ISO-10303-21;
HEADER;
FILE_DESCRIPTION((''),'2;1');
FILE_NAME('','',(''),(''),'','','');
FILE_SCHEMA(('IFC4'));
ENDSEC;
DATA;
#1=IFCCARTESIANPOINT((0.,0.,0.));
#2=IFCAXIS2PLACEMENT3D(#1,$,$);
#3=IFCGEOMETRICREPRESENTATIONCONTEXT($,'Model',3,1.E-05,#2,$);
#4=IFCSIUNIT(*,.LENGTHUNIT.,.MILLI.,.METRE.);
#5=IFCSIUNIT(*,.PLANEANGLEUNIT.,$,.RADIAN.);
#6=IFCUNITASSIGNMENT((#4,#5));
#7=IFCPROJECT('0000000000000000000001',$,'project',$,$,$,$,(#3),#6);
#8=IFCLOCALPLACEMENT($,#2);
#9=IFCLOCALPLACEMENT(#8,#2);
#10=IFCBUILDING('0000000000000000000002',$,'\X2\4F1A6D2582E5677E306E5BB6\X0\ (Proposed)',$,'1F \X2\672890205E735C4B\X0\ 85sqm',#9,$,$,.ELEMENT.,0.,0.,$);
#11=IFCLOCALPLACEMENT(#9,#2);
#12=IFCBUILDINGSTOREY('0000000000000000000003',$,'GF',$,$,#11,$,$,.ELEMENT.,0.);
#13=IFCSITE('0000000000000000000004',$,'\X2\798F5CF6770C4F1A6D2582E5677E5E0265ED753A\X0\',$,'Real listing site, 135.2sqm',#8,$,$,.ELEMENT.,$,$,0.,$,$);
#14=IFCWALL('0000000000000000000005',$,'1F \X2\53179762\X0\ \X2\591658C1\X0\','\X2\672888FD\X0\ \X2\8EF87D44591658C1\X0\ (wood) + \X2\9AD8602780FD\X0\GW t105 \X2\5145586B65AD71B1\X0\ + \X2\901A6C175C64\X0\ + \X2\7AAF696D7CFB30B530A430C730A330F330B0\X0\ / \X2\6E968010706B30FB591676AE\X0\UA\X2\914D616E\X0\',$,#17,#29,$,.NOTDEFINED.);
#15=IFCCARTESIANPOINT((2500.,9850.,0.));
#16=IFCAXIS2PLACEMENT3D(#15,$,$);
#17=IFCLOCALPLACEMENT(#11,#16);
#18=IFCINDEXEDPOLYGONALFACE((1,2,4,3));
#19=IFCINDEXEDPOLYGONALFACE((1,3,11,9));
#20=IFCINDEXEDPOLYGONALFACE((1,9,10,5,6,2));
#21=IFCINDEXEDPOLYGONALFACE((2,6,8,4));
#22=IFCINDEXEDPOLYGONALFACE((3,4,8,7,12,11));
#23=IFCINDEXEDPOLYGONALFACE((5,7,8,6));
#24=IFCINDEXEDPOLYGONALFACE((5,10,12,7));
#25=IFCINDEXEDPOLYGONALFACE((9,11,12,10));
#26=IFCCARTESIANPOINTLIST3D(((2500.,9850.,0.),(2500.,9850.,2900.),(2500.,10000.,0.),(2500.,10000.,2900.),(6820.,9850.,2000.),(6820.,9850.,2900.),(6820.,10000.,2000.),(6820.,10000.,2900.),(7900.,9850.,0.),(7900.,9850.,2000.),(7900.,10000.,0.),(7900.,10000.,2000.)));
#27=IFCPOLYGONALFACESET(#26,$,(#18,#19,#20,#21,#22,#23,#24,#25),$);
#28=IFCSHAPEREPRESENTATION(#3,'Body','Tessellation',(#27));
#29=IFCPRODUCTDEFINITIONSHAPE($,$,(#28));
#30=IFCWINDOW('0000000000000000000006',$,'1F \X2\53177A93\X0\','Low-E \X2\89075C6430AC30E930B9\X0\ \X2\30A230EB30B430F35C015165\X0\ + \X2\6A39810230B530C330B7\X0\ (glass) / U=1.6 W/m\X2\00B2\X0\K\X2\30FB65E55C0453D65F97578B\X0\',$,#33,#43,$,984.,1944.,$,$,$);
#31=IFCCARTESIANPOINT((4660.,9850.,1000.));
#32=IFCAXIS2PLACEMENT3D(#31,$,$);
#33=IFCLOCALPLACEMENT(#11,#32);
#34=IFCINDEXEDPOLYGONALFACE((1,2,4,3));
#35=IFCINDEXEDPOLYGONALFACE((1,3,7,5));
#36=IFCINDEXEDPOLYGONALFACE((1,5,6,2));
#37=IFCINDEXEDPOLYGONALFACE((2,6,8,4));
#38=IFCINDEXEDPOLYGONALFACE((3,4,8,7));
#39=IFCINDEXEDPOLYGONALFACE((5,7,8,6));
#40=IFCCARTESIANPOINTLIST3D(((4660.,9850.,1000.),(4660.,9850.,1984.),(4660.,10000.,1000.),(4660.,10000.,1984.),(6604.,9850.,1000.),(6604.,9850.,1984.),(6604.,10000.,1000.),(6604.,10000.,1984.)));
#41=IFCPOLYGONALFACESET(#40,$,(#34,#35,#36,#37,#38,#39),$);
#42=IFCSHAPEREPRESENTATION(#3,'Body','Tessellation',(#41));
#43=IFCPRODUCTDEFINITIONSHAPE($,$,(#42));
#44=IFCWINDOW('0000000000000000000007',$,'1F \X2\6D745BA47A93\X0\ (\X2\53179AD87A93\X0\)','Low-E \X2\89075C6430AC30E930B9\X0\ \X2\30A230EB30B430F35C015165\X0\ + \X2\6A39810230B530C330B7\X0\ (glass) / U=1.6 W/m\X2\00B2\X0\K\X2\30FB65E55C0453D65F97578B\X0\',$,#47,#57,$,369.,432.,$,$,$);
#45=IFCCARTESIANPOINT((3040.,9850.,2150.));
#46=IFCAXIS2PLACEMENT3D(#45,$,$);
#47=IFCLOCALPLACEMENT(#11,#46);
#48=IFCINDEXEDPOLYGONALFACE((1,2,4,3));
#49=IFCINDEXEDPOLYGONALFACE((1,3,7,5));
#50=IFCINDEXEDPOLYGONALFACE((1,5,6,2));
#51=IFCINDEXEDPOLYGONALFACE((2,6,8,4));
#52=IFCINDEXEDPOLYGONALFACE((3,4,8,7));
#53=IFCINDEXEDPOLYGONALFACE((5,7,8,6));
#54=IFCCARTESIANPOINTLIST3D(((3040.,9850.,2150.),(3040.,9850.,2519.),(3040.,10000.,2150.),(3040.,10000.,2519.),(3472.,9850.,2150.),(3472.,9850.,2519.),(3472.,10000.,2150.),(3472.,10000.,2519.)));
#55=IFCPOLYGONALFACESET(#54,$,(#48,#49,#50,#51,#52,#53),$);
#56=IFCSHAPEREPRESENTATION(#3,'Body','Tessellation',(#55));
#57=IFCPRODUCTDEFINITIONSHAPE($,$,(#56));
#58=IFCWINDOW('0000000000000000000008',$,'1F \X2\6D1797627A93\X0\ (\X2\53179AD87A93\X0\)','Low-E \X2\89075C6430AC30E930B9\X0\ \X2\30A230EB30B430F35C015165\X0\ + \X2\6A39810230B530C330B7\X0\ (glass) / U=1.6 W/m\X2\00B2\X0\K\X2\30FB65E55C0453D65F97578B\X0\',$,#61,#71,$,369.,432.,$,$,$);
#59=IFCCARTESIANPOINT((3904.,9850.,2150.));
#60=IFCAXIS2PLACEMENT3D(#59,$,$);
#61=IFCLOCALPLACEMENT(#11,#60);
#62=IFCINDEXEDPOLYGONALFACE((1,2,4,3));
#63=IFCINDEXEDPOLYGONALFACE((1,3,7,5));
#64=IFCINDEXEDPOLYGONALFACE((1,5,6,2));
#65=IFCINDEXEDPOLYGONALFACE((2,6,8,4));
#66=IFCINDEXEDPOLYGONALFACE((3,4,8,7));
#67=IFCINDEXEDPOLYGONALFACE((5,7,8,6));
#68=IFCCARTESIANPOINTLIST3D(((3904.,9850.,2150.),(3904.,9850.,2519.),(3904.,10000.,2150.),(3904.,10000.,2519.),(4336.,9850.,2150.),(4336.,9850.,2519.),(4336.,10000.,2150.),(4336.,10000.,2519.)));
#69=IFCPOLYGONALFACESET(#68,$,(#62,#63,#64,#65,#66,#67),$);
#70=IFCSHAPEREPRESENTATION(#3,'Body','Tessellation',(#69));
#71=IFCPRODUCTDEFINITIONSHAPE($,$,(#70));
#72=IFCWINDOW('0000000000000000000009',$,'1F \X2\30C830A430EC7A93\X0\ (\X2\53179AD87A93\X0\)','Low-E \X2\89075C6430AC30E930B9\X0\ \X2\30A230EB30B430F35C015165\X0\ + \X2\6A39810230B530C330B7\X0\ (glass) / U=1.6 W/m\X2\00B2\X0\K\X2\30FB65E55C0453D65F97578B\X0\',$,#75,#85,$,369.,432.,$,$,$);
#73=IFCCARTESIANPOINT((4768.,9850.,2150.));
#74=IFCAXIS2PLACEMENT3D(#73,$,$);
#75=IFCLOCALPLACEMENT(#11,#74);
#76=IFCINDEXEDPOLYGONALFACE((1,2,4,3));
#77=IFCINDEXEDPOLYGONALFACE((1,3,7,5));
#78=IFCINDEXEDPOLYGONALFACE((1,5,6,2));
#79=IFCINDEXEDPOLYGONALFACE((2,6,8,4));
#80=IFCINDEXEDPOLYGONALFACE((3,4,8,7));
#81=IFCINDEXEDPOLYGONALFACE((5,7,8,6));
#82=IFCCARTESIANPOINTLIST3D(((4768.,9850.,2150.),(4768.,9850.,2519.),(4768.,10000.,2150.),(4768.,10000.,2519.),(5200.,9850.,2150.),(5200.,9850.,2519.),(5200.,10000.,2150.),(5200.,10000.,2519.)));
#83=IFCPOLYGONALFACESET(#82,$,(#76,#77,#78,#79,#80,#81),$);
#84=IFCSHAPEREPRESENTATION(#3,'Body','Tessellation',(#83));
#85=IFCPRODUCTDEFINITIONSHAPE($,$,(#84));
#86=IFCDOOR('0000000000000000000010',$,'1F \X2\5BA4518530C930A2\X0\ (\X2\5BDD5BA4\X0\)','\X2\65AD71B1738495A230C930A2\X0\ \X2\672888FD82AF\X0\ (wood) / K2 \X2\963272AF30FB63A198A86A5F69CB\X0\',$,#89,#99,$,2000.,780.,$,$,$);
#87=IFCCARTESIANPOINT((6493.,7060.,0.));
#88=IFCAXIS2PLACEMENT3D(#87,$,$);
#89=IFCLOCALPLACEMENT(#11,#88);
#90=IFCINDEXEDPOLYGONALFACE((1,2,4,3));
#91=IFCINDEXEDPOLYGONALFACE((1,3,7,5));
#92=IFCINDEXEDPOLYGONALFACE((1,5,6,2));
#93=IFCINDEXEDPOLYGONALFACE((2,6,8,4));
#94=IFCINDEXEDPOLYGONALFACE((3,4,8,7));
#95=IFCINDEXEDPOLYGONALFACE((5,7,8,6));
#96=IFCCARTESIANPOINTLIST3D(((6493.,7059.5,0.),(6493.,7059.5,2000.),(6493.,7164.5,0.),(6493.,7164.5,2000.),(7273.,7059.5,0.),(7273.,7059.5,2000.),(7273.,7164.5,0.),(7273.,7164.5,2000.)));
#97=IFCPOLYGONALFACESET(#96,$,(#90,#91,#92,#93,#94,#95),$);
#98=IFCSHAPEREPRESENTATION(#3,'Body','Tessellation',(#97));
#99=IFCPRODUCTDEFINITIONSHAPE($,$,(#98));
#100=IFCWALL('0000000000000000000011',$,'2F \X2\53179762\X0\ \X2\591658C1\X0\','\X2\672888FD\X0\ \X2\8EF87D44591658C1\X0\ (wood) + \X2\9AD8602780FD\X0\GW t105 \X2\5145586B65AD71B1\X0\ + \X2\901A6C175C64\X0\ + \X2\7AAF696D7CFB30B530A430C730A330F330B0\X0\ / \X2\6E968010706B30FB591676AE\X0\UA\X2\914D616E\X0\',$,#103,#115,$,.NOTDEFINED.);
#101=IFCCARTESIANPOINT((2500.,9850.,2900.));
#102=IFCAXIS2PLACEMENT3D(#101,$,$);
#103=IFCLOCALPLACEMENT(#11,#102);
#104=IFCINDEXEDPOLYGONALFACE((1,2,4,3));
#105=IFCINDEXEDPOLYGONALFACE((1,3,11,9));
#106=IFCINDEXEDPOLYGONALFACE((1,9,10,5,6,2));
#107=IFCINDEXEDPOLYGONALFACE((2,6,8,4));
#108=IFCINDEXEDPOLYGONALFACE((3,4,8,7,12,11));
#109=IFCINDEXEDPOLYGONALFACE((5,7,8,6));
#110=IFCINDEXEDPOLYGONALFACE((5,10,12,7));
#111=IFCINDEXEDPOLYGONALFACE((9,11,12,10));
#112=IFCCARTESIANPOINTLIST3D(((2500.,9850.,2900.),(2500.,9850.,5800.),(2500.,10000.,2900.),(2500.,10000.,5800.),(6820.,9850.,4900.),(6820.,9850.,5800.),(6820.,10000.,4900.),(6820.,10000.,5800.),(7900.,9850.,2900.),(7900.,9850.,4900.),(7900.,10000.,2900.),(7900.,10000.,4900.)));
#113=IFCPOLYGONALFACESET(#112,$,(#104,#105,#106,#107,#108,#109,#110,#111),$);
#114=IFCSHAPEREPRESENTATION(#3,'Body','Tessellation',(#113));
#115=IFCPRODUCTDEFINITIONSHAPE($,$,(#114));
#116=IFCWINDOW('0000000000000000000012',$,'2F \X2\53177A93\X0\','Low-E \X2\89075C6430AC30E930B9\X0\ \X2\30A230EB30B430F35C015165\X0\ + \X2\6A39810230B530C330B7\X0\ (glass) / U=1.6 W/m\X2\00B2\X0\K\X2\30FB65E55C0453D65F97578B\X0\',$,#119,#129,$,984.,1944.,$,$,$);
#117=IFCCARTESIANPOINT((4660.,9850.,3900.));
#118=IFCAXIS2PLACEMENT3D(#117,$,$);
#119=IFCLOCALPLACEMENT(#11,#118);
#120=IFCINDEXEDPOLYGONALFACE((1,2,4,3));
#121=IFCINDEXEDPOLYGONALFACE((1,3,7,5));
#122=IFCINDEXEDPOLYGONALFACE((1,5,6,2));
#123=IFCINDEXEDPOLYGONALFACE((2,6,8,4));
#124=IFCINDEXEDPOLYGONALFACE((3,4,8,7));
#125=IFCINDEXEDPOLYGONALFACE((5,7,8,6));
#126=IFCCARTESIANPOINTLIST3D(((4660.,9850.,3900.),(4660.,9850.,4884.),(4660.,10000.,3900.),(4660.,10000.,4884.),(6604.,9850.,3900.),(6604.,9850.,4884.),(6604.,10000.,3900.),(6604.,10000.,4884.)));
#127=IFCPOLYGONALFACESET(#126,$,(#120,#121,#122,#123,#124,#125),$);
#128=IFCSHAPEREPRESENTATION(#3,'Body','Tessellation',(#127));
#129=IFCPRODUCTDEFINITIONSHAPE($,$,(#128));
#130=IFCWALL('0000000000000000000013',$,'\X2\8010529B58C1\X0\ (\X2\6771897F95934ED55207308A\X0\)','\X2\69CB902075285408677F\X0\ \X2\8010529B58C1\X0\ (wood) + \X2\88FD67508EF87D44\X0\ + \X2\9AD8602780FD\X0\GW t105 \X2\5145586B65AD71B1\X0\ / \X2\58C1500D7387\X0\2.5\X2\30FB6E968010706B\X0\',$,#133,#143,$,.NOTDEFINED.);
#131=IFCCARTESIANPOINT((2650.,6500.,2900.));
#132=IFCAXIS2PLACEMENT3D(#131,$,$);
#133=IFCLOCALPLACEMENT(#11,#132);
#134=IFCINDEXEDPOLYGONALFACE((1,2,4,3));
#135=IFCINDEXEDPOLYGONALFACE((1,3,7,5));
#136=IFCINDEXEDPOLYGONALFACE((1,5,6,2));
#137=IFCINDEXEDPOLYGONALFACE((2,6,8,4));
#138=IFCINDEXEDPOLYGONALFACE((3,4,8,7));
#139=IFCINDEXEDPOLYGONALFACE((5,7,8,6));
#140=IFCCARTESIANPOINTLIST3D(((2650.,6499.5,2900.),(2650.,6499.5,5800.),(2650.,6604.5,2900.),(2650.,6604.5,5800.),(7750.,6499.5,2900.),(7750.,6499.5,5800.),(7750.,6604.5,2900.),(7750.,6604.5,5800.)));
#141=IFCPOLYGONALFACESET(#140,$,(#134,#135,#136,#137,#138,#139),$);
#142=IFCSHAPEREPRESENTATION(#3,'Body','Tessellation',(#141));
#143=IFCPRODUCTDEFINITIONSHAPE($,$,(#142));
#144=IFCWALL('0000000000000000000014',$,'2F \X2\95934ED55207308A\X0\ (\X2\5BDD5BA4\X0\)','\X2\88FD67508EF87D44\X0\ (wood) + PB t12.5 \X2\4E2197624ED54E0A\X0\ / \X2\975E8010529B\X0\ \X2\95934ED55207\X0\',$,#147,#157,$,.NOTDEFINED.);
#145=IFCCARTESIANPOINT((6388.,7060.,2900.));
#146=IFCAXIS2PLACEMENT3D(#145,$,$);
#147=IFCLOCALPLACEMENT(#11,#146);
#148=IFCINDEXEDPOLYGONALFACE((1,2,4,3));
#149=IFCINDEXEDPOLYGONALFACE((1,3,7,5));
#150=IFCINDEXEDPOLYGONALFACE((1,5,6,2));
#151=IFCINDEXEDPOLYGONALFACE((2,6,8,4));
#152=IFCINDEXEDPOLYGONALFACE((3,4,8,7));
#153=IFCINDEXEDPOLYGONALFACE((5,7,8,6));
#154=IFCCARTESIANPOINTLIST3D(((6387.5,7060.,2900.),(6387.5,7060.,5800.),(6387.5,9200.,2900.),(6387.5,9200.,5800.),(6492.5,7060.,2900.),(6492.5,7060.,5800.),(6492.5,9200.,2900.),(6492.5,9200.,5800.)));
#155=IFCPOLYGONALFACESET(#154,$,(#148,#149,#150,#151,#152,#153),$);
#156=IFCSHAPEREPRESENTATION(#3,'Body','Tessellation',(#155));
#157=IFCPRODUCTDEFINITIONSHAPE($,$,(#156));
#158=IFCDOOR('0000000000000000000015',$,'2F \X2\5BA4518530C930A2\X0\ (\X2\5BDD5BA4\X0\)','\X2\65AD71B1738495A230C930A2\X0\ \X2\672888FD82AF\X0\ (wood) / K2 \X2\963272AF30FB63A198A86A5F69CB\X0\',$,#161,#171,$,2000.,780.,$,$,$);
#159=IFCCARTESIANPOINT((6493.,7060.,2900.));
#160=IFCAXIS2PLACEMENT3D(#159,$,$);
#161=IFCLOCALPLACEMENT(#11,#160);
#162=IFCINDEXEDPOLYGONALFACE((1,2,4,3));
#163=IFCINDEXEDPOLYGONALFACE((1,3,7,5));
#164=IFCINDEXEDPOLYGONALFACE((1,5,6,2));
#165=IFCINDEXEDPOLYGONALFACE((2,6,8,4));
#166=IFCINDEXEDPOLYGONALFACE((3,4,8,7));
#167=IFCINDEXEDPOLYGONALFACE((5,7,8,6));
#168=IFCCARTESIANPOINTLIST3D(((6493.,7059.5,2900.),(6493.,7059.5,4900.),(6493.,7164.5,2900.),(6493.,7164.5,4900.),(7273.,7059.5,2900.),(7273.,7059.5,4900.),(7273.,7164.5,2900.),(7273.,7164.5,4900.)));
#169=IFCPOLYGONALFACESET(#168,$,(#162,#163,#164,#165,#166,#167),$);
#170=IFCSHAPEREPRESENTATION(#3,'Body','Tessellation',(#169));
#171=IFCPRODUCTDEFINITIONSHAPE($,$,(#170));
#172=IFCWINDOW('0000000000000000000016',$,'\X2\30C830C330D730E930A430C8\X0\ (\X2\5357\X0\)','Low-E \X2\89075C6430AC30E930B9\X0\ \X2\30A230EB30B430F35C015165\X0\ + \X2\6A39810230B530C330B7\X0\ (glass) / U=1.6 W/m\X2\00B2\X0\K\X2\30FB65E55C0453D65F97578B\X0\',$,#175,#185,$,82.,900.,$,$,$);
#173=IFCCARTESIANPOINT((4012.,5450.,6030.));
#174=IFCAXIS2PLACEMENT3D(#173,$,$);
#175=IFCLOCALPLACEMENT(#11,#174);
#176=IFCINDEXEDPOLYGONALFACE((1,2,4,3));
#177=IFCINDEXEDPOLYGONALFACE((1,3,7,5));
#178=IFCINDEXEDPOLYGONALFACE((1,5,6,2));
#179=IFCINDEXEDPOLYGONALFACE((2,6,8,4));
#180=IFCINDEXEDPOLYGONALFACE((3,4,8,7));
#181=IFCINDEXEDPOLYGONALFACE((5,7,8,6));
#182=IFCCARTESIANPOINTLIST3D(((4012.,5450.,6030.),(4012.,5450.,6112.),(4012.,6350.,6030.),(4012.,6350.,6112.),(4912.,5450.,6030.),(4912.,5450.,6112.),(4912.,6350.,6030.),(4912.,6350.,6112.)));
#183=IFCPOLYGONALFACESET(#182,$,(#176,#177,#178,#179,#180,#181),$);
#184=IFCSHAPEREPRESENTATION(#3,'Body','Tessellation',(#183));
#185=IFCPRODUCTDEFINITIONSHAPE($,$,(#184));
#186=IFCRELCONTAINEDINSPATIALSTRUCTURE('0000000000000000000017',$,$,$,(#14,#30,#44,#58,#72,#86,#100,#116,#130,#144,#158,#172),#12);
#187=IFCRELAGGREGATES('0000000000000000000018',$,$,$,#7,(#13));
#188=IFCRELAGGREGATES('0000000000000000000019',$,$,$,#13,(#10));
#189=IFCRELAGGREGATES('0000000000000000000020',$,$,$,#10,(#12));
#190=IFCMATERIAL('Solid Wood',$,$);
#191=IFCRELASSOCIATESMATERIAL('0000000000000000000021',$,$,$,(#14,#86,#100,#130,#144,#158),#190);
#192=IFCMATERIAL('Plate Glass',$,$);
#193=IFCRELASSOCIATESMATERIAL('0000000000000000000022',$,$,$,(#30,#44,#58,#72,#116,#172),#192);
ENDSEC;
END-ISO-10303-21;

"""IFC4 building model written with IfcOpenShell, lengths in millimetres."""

from ifc_helpers import new_model, si_unit, frame, frame_2d, origin, place, context, project, spatial, rectangle, extrude, material, element, fill, save


model = new_model("IFC4")

# Units and contexts
model_context = context("Model", 3, precision=1e-05, world=origin())
ifc_project = project(units=[si_unit("LENGTHUNIT", "METRE", prefix="MILLI"), si_unit("PLANEANGLEUNIT", "RADIAN")], contexts=[model_context])

# Site, building, storey
site_placement = place(None, origin())
site = spatial("IfcSite", under=ifc_project, at=site_placement, Name="福島県会津若松市旭町", ObjectType="Real listing site, 135.2sqm", CompositionType="ELEMENT", RefElevation=0.0)
building_placement = place(site_placement, origin())
building = spatial("IfcBuilding", under=site, at=building_placement, Name="会津若松の家 (Proposed)", ObjectType="1F 木造平屋 85sqm", CompositionType="ELEMENT", ElevationOfRefHeight=0.0, ElevationOfTerrain=0.0)
storey_placement = place(building_placement, origin())
storey = spatial("IfcBuildingStorey", under=building, at=storey_placement, Name="GF", CompositionType="ELEMENT", Elevation=0.0)

# Wall, openings, windows
ifc_material_1 = material(Name="Solid Wood")
wall_1_placement = place(storey_placement, frame((2500.0, 9850.0, 0.0)))
wall_1 = element("IfcWall", 1, at=wall_1_placement, inside=storey, material=ifc_material_1, Name="1F 北面 外壁", Description="木製 軸組外壁 (wood) + 高性能GW t105 充填断熱 + 通気層 + 窯業系サイディング / 準耐火・外皮UA配慮", PredefinedType="NOTDEFINED", context=model_context, shape_type="SweptSolid", body=[
    extrude(rectangle(XDim=5400.0, YDim=150.0, at=frame_2d((2700.0, 75.0))), frame((2500.0, 9850.0, 0.0)), (0.0, 0.0, 1.0), 2900.0),
])
opening_1_placement = place(storey_placement, frame((4660.0, 9850.0, 1000.0)))
opening_1 = element("IfcOpeningElement", 2, at=opening_1_placement, cuts=wall_1, PredefinedType="NOTDEFINED", context=model_context, shape_type="SweptSolid", body=[
    extrude(rectangle(XDim=1944.0, YDim=150.0, at=frame_2d((972.0, 75.0))), frame((4660.0, 9850.0, 1000.0)), (0.0, 0.0, 1.0), 984.0),
])
opening_2_placement = place(storey_placement, frame((3040.0, 9850.0, 2150.0)))
opening_2 = element("IfcOpeningElement", 3, at=opening_2_placement, cuts=wall_1, PredefinedType="NOTDEFINED", context=model_context, shape_type="SweptSolid", body=[
    extrude(rectangle(XDim=432.0, YDim=150.0, at=frame_2d((216.0, 75.0))), frame((3040.0, 9850.0, 2150.0)), (0.0, 0.0, 1.0), 369.0),
])
opening_3_placement = place(storey_placement, frame((3904.0, 9850.0, 2150.0)))
opening_3 = element("IfcOpeningElement", 4, at=opening_3_placement, cuts=wall_1, PredefinedType="NOTDEFINED", context=model_context, shape_type="SweptSolid", body=[
    extrude(rectangle(XDim=432.0, YDim=150.0, at=frame_2d((216.0, 75.0))), frame((3904.0, 9850.0, 2150.0)), (0.0, 0.0, 1.0), 369.0),
])
opening_4_placement = place(storey_placement, frame((4768.0, 9850.0, 2150.0)))
opening_4 = element("IfcOpeningElement", 5, at=opening_4_placement, cuts=wall_1, PredefinedType="NOTDEFINED", context=model_context, shape_type="SweptSolid", body=[
    extrude(rectangle(XDim=432.0, YDim=150.0, at=frame_2d((216.0, 75.0))), frame((4768.0, 9850.0, 2150.0)), (0.0, 0.0, 1.0), 369.0),
])
ifc_material_2 = material(Name="Plate Glass")
window_1_placement = place(storey_placement, frame((4660.0, 9850.0, 1000.0)))
window_1 = element("IfcWindow", 6, at=window_1_placement, inside=storey, material=ifc_material_2, Name="1F 北窓", Description="Low-E 複層ガラス アルゴン封入 + 樹脂サッシ (glass) / U=1.6 W/m²K・日射取得型", OverallHeight=984.0, OverallWidth=1944.0, context=model_context, shape_type="SweptSolid", body=[
    extrude(rectangle(XDim=1944.0, YDim=150.0, at=frame_2d((972.0, 75.0))), frame((4660.0, 9850.0, 1000.0)), (0.0, 0.0, 1.0), 984.0),
])
fill(opening_1, window_1)
window_2_placement = place(storey_placement, frame((3040.0, 9850.0, 2150.0)))
window_2 = element("IfcWindow", 7, at=window_2_placement, inside=storey, material=ifc_material_2, Name="1F 浴室窓 (北高窓)", Description="Low-E 複層ガラス アルゴン封入 + 樹脂サッシ (glass) / U=1.6 W/m²K・日射取得型", OverallHeight=369.0, OverallWidth=432.0, context=model_context, shape_type="SweptSolid", body=[
    extrude(rectangle(XDim=432.0, YDim=150.0, at=frame_2d((216.0, 75.0))), frame((3040.0, 9850.0, 2150.0)), (0.0, 0.0, 1.0), 369.0),
])
fill(opening_2, window_2)
window_3_placement = place(storey_placement, frame((3904.0, 9850.0, 2150.0)))
window_3 = element("IfcWindow", 8, at=window_3_placement, inside=storey, material=ifc_material_2, Name="1F 洗面窓 (北高窓)", Description="Low-E 複層ガラス アルゴン封入 + 樹脂サッシ (glass) / U=1.6 W/m²K・日射取得型", OverallHeight=369.0, OverallWidth=432.0, context=model_context, shape_type="SweptSolid", body=[
    extrude(rectangle(XDim=432.0, YDim=150.0, at=frame_2d((216.0, 75.0))), frame((3904.0, 9850.0, 2150.0)), (0.0, 0.0, 1.0), 369.0),
])
fill(opening_3, window_3)
window_4_placement = place(storey_placement, frame((4768.0, 9850.0, 2150.0)))
window_4 = element("IfcWindow", 9, at=window_4_placement, inside=storey, material=ifc_material_2, Name="1F トイレ窓 (北高窓)", Description="Low-E 複層ガラス アルゴン封入 + 樹脂サッシ (glass) / U=1.6 W/m²K・日射取得型", OverallHeight=369.0, OverallWidth=432.0, context=model_context, shape_type="SweptSolid", body=[
    extrude(rectangle(XDim=432.0, YDim=150.0, at=frame_2d((216.0, 75.0))), frame((4768.0, 9850.0, 2150.0)), (0.0, 0.0, 1.0), 369.0),
])
fill(opening_4, window_4)

# Door
door_1_placement = place(storey_placement, frame((6493.0, 7060.0, 0.0)))
element("IfcDoor", 10, at=door_1_placement, inside=storey, material=ifc_material_1, Name="1F 室内ドア (寝室)", Description="断熱玄関ドア 木製芯 (wood) / K2 防犯・採風機構", OverallHeight=2000.0, OverallWidth=780.0, context=model_context, shape_type="SweptSolid", body=[
    extrude(rectangle(XDim=780.0, YDim=105.0, at=frame_2d((390.0, 52.0))), frame((6493.0, 7060.0, 0.0)), (0.0, 0.0, 1.0), 2000.0),
])

# Wall, opening, window
wall_2_placement = place(storey_placement, frame((2500.0, 9850.0, 2900.0)))
wall_2 = element("IfcWall", 11, at=wall_2_placement, inside=storey, material=ifc_material_1, Name="2F 北面 外壁", Description="木製 軸組外壁 (wood) + 高性能GW t105 充填断熱 + 通気層 + 窯業系サイディング / 準耐火・外皮UA配慮", PredefinedType="NOTDEFINED", context=model_context, shape_type="SweptSolid", body=[
    extrude(rectangle(XDim=5400.0, YDim=150.0, at=frame_2d((2700.0, 75.0))), frame((2500.0, 9850.0, 2900.0)), (0.0, 0.0, 1.0), 2900.0),
])
opening_5_placement = place(storey_placement, frame((4660.0, 9850.0, 3900.0)))
opening_5 = element("IfcOpeningElement", 12, at=opening_5_placement, cuts=wall_2, PredefinedType="NOTDEFINED", context=model_context, shape_type="SweptSolid", body=[
    extrude(rectangle(XDim=1944.0, YDim=150.0, at=frame_2d((972.0, 75.0))), frame((4660.0, 9850.0, 3900.0)), (0.0, 0.0, 1.0), 984.0),
])
window_5_placement = place(storey_placement, frame((4660.0, 9850.0, 3900.0)))
window_5 = element("IfcWindow", 13, at=window_5_placement, inside=storey, material=ifc_material_2, Name="2F 北窓", Description="Low-E 複層ガラス アルゴン封入 + 樹脂サッシ (glass) / U=1.6 W/m²K・日射取得型", OverallHeight=984.0, OverallWidth=1944.0, context=model_context, shape_type="SweptSolid", body=[
    extrude(rectangle(XDim=1944.0, YDim=150.0, at=frame_2d((972.0, 75.0))), frame((4660.0, 9850.0, 3900.0)), (0.0, 0.0, 1.0), 984.0),
])
fill(opening_5, window_5)

# Walls
wall_3_placement = place(storey_placement, frame((2650.0, 6500.0, 2900.0)))
element("IfcWall", 14, at=wall_3_placement, inside=storey, material=ifc_material_1, Name="耐力壁 (東西間仕切り)", Description="構造用合板 耐力壁 (wood) + 製材軸組 + 高性能GW t105 充填断熱 / 壁倍率2.5・準耐火", PredefinedType="NOTDEFINED", context=model_context, shape_type="SweptSolid", body=[
    extrude(rectangle(XDim=5100.0, YDim=105.0, at=frame_2d((2550.0, 52.0))), frame((2650.0, 6500.0, 2900.0)), (0.0, 0.0, 1.0), 2900.0),
])
wall_4_placement = place(storey_placement, frame((6388.0, 7060.0, 2900.0)))
element("IfcWall", 15, at=wall_4_placement, inside=storey, material=ifc_material_1, Name="2F 間仕切り (寝室)", Description="製材軸組 (wood) + PB t12.5 両面仕上 / 非耐力 間仕切", PredefinedType="NOTDEFINED", context=model_context, shape_type="SweptSolid", body=[
    extrude(rectangle(XDim=105.0, YDim=2140.0, at=frame_2d((52.0, 1070.0))), frame((6388.0, 7060.0, 2900.0)), (0.0, 0.0, 1.0), 2900.0),
])

# Door
door_2_placement = place(storey_placement, frame((6493.0, 7060.0, 2900.0)))
element("IfcDoor", 16, at=door_2_placement, inside=storey, material=ifc_material_1, Name="2F 室内ドア (寝室)", Description="断熱玄関ドア 木製芯 (wood) / K2 防犯・採風機構", OverallHeight=2000.0, OverallWidth=780.0, context=model_context, shape_type="SweptSolid", body=[
    extrude(rectangle(XDim=780.0, YDim=105.0, at=frame_2d((390.0, 52.0))), frame((6493.0, 7060.0, 2900.0)), (0.0, 0.0, 1.0), 2000.0),
])

# Window
window_6_placement = place(storey_placement, frame((4012.0, 5450.0, 6030.0)))
element("IfcWindow", 17, at=window_6_placement, inside=storey, material=ifc_material_2, Name="トップライト (南)", Description="Low-E 複層ガラス アルゴン封入 + 樹脂サッシ (glass) / U=1.6 W/m²K・日射取得型", OverallHeight=82.0, OverallWidth=900.0, context=model_context, shape_type="SweptSolid", body=[
    extrude(rectangle(XDim=900.0, YDim=900.0, at=frame_2d((450.0, 450.0))), frame((4012.0, 5450.0, 6030.0)), (0.0, 0.0, 1.0), 82.0),
])

save(model, "model.ifc")
